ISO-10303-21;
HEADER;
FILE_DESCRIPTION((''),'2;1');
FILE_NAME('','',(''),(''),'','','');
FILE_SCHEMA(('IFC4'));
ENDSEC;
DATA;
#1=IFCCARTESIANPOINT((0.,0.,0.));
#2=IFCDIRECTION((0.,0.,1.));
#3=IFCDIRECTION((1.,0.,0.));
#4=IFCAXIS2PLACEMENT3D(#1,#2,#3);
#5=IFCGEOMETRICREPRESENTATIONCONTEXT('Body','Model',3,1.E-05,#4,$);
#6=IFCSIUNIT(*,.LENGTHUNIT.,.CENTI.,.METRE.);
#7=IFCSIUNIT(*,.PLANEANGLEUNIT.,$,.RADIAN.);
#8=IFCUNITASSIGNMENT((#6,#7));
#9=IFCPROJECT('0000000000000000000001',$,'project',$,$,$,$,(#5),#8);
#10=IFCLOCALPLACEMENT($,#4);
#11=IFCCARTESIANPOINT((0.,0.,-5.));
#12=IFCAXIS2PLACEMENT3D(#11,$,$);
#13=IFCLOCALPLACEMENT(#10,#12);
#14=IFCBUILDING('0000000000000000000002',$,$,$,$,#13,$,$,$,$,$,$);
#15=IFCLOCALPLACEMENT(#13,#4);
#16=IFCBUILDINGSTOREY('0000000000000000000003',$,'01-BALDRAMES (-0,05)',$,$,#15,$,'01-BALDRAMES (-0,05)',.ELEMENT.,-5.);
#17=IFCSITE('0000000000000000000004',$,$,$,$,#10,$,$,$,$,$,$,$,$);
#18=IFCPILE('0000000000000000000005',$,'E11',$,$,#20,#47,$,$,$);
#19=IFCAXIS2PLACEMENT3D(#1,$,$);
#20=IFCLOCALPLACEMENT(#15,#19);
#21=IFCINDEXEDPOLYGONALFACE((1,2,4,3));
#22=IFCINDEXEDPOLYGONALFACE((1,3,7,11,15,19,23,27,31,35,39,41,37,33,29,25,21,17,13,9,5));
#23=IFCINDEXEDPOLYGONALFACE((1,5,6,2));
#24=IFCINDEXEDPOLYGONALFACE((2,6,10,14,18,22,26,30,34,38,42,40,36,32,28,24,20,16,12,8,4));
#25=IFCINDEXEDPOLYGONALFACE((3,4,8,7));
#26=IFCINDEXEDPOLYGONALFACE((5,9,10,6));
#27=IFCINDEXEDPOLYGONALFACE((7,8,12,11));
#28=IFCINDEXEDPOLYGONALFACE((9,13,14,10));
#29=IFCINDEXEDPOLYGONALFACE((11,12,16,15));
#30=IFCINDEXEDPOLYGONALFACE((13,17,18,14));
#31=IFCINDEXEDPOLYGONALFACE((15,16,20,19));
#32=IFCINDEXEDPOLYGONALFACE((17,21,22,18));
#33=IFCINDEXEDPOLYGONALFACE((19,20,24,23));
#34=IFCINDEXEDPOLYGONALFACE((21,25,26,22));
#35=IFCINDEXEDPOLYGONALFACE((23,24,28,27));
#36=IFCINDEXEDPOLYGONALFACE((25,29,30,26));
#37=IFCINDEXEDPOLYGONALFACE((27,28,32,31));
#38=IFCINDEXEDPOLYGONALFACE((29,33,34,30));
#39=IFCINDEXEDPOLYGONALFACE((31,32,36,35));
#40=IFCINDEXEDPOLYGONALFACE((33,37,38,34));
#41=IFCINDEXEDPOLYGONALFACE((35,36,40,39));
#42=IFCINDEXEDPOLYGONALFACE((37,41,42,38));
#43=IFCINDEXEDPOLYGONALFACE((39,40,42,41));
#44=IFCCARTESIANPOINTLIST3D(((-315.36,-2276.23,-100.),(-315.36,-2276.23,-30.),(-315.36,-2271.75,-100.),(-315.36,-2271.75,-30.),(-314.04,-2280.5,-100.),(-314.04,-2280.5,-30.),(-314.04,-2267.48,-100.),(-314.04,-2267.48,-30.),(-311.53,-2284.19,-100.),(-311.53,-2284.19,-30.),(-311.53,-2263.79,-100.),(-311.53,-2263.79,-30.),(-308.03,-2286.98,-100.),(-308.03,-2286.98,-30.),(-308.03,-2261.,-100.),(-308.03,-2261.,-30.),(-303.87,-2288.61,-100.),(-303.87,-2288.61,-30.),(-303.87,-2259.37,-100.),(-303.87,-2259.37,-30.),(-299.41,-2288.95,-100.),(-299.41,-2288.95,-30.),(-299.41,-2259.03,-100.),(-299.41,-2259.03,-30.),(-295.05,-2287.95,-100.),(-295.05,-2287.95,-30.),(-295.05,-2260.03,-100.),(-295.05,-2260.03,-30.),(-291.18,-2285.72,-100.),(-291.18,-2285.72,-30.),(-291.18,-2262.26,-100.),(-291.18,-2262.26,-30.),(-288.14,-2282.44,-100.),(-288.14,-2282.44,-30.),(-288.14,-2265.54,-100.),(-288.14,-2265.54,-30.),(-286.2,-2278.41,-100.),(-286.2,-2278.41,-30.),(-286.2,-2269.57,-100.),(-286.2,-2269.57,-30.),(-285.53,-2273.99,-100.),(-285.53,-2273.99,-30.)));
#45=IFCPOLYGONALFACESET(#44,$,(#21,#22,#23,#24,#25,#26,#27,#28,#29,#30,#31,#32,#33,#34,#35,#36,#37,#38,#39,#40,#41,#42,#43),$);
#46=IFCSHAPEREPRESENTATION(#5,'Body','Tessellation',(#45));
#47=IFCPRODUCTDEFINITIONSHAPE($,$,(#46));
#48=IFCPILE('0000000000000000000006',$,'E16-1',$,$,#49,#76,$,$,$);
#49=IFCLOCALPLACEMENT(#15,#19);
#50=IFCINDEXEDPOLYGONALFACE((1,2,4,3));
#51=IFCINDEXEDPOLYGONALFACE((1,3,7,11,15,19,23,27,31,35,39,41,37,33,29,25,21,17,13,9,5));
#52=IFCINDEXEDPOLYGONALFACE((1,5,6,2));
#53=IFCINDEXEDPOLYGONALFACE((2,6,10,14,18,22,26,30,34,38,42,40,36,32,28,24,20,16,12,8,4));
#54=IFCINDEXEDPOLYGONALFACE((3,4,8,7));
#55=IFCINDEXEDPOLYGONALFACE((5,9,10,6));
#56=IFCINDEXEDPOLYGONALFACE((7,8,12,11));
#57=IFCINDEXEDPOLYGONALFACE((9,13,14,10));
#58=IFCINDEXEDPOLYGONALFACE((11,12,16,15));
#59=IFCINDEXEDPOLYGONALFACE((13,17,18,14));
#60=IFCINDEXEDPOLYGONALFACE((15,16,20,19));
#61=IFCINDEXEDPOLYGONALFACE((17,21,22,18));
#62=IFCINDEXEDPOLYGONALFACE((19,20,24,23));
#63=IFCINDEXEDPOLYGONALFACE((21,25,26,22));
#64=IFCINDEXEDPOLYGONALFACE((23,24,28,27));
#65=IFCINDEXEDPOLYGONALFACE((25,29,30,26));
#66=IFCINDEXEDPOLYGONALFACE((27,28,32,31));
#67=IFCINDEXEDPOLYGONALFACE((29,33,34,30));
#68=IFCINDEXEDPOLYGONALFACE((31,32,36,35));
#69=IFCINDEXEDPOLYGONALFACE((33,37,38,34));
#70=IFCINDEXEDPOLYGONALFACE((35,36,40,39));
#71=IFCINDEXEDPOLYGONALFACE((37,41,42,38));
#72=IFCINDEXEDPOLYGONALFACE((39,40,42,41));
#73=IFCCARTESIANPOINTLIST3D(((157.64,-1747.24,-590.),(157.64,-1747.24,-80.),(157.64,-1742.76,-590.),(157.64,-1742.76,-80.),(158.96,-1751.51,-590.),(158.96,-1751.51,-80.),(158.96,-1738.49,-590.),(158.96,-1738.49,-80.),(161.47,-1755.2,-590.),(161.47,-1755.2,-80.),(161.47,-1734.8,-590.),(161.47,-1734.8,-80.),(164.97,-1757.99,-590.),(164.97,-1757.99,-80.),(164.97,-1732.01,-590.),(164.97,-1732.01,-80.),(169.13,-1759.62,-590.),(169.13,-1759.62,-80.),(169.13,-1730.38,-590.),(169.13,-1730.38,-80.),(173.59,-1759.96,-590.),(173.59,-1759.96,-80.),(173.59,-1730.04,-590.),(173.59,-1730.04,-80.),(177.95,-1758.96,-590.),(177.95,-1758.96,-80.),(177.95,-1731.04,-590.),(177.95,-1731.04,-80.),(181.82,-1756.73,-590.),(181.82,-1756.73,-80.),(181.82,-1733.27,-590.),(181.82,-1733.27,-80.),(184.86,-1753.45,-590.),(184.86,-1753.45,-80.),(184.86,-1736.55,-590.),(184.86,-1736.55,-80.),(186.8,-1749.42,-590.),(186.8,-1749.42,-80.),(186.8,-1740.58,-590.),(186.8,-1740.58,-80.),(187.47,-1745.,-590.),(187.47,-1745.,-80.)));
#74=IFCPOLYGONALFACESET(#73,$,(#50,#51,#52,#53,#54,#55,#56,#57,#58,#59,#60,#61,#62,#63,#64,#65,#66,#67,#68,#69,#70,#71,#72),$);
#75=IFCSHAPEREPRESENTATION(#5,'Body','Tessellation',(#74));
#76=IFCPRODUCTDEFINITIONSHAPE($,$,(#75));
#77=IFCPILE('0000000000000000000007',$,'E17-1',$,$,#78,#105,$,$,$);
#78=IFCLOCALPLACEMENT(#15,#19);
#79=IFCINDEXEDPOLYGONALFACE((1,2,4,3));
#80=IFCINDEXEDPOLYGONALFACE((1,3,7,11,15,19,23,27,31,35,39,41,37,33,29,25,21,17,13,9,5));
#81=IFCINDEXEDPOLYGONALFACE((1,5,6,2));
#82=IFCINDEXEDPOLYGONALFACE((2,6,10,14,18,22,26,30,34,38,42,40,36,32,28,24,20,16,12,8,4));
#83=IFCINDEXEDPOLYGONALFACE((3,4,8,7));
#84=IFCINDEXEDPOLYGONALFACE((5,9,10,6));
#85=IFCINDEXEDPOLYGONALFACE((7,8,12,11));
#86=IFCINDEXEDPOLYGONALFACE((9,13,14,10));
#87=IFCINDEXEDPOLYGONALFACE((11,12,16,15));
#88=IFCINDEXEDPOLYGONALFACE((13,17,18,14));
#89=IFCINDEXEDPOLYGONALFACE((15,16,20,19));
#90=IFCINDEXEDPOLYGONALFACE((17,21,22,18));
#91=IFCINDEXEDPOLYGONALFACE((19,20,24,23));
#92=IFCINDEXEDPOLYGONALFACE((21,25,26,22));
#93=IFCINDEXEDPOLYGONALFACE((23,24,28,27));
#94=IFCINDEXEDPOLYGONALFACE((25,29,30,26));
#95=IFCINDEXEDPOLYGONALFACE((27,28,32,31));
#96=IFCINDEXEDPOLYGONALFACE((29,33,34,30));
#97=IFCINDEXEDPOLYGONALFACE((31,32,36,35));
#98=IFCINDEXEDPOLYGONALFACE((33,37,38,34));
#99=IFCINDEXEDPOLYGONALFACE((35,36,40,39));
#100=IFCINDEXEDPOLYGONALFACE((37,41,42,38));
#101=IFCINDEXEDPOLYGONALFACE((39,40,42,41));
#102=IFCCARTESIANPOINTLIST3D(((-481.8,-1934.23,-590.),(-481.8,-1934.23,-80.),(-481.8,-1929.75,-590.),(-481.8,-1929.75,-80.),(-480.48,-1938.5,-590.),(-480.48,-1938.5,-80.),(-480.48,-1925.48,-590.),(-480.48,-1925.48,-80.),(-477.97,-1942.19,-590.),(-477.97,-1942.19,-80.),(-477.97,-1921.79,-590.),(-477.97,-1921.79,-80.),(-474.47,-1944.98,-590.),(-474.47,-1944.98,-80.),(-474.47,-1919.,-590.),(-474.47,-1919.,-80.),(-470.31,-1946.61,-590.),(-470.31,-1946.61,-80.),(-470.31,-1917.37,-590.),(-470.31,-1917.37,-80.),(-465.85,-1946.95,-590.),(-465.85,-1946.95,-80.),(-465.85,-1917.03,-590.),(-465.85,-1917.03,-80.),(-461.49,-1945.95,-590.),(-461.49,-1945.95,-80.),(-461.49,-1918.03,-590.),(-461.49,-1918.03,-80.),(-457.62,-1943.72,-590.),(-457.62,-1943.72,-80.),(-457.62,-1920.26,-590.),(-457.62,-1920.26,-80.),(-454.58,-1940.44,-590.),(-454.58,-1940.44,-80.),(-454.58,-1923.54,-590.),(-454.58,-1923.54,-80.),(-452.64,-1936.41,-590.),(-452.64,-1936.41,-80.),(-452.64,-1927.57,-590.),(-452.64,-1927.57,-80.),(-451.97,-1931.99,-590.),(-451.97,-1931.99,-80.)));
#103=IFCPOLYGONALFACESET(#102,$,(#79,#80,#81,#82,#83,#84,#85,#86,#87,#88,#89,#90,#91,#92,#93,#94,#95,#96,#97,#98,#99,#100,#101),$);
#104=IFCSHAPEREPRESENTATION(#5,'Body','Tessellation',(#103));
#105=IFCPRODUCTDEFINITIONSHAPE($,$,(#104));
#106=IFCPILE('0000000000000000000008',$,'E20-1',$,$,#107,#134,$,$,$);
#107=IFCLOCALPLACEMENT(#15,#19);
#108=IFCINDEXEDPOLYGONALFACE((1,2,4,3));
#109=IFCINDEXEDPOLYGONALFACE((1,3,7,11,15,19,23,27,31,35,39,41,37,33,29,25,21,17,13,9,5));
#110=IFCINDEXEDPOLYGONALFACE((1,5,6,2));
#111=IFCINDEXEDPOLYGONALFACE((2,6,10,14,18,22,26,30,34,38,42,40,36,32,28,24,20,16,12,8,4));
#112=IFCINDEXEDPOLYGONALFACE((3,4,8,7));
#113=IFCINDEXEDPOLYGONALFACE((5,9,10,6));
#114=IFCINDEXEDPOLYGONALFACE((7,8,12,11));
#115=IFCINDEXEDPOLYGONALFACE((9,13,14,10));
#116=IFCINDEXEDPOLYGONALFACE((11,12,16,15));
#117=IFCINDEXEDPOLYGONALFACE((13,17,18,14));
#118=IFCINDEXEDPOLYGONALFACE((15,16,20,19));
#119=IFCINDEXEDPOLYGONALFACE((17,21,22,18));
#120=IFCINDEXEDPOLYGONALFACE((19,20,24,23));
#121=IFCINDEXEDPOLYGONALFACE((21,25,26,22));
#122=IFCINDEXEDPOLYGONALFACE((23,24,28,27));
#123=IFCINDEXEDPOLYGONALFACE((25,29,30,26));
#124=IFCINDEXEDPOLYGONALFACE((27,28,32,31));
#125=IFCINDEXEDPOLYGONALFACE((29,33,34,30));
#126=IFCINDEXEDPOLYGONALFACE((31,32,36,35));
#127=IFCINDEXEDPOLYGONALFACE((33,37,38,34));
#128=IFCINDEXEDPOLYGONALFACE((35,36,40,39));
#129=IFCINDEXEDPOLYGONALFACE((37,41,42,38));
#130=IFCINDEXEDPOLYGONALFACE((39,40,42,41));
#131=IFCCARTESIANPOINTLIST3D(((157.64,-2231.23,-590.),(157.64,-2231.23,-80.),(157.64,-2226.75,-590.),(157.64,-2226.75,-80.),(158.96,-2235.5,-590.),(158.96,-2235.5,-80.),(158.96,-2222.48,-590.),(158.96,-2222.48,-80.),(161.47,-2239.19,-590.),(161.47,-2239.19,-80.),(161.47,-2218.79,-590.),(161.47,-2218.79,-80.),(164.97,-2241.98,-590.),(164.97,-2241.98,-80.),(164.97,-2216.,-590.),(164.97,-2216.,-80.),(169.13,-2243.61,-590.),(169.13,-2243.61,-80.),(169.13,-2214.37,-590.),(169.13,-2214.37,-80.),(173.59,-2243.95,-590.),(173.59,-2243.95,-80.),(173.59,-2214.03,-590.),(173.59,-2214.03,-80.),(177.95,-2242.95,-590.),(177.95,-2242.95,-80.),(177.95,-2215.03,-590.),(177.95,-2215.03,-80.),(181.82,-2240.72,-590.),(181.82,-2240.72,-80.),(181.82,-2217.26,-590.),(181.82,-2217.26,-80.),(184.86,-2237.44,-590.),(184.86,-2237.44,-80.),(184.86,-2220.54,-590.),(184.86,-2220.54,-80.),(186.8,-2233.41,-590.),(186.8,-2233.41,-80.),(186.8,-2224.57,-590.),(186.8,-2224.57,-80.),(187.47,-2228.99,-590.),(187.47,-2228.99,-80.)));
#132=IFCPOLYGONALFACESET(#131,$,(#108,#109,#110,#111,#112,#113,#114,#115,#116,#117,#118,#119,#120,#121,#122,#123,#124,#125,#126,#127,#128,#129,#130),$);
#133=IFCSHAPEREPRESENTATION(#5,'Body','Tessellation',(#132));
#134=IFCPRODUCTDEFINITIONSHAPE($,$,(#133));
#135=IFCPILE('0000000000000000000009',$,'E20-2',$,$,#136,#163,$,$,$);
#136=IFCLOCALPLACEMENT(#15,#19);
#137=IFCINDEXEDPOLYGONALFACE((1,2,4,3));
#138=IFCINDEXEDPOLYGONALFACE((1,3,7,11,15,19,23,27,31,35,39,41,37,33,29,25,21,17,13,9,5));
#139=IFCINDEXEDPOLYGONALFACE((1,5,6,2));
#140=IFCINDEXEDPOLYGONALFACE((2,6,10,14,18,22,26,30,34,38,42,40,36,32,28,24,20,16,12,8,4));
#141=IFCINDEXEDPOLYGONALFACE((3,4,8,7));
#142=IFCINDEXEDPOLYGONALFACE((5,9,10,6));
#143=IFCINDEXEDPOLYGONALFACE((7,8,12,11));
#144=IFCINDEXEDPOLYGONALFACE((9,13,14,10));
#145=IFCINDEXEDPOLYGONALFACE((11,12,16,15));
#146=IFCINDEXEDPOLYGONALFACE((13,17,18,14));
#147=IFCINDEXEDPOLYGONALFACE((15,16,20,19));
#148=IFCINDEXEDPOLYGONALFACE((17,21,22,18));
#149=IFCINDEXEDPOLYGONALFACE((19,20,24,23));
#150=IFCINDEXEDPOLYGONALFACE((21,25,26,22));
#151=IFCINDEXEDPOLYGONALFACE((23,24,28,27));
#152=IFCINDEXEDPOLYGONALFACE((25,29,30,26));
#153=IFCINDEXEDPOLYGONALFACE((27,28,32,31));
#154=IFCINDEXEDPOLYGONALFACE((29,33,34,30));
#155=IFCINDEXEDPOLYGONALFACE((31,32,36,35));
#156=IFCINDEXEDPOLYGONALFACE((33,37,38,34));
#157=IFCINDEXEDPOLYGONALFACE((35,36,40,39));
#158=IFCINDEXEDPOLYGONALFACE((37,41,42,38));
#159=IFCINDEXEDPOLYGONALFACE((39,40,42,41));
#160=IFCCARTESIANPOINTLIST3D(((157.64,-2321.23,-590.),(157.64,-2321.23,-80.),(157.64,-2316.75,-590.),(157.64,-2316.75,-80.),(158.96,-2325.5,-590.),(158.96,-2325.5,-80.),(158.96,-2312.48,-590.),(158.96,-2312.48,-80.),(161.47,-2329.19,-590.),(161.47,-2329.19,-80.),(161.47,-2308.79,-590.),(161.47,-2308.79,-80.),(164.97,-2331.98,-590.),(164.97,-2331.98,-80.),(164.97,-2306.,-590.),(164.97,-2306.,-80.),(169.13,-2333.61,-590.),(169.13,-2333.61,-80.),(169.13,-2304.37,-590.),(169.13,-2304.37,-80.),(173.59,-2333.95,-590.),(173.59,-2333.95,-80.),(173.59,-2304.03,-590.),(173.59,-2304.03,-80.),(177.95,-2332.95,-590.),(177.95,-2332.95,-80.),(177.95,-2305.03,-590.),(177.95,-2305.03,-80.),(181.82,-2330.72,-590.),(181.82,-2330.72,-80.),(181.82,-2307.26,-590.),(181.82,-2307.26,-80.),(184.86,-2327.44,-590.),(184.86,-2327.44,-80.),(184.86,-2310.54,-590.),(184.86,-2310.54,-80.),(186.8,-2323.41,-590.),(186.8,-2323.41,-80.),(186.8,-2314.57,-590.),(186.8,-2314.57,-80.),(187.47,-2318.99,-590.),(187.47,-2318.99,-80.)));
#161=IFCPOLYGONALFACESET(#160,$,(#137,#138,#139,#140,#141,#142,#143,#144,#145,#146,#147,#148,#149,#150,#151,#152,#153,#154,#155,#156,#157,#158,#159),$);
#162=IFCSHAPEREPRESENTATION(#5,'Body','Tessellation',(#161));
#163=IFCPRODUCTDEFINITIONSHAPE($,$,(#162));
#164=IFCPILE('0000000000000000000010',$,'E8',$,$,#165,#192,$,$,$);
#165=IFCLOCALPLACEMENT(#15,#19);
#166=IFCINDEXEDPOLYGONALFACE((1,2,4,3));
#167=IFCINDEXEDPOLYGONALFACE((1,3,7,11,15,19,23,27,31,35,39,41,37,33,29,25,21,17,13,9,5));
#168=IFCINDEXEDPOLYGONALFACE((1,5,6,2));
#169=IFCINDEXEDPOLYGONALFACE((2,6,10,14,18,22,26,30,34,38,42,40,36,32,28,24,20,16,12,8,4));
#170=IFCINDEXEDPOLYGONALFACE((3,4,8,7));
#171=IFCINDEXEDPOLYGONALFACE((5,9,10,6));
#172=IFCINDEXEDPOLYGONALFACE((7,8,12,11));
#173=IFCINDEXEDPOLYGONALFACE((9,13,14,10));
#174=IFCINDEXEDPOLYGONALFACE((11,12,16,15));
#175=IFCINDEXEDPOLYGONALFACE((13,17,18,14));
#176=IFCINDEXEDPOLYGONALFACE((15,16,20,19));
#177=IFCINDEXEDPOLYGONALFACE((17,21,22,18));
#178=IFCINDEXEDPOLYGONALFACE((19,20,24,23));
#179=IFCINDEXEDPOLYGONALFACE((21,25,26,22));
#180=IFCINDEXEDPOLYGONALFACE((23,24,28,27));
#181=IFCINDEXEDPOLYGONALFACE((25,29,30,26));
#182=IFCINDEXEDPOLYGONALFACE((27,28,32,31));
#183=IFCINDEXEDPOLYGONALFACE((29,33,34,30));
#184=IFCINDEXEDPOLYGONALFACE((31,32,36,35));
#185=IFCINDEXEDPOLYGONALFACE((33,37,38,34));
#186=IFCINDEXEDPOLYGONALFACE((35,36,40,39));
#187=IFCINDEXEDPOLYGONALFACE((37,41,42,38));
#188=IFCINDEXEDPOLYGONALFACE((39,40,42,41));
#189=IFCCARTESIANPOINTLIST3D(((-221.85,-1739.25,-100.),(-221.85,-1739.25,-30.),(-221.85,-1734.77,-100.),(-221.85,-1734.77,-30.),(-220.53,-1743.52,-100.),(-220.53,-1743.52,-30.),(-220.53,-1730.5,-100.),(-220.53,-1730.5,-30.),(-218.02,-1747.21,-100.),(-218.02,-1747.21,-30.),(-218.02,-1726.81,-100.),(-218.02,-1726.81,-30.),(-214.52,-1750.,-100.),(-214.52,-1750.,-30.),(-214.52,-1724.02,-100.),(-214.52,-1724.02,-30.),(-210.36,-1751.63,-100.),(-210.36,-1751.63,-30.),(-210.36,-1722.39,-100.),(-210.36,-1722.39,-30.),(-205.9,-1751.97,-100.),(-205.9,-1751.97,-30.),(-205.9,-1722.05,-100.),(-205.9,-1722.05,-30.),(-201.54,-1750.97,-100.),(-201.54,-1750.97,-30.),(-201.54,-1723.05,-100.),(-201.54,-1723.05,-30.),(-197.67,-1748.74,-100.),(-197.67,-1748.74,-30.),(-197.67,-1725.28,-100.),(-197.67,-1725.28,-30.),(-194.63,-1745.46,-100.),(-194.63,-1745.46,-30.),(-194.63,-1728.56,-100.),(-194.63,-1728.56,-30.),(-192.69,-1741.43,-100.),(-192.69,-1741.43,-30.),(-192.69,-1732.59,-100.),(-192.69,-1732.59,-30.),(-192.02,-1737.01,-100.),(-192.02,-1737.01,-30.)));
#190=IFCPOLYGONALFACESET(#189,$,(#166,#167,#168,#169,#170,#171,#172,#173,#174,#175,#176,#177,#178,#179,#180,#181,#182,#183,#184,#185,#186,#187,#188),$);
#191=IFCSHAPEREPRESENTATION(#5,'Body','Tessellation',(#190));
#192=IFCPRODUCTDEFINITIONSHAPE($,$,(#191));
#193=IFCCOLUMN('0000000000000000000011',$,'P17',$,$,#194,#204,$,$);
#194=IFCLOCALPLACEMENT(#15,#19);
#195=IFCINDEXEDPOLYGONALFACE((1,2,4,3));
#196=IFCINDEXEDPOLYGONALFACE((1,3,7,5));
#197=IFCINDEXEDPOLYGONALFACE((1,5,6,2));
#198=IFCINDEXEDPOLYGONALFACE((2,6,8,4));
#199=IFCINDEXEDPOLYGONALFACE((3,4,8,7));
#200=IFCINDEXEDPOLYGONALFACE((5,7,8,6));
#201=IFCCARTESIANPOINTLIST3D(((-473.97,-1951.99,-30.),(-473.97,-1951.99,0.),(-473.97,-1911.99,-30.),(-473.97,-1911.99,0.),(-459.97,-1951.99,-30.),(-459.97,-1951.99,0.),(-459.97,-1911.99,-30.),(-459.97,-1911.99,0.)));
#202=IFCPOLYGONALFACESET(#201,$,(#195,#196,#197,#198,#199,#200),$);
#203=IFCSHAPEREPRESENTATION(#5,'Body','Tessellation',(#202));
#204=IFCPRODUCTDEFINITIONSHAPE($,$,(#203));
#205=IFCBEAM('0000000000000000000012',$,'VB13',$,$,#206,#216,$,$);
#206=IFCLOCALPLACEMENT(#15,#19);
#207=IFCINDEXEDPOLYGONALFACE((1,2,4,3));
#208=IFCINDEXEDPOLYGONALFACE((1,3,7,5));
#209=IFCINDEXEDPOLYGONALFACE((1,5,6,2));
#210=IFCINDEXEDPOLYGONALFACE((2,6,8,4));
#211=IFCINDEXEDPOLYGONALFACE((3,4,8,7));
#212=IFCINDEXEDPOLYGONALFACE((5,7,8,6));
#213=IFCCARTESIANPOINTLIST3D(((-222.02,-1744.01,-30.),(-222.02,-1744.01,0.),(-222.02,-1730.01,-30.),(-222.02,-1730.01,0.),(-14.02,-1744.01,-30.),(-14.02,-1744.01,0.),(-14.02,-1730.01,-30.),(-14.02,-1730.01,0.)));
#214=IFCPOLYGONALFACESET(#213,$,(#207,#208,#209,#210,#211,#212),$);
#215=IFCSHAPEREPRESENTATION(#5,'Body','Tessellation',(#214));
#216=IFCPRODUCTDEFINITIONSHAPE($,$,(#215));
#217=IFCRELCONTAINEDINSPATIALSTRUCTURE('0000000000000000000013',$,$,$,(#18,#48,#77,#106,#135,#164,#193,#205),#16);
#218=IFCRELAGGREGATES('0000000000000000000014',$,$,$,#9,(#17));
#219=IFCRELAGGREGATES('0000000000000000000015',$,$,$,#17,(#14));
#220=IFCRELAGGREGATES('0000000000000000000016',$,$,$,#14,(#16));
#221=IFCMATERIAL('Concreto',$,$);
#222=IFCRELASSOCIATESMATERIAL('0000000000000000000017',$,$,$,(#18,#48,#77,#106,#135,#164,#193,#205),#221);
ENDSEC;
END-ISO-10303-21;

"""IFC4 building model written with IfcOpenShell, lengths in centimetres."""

from ifc_helpers import new_model, si_unit, frame, origin_with_axes, origin_2d_with_axis, place, context, project, spatial, rectangle, circle, extrude, material, element, save


model = new_model("IFC4")

# Units and contexts
model_context = context("Model", 3, precision=1e-05, world=origin_with_axes(), identifier="Body")
ifc_project = project(units=[si_unit("LENGTHUNIT", "METRE", prefix="CENTI"), si_unit("PLANEANGLEUNIT", "RADIAN")], contexts=[model_context])

# Site, building, storey
site_placement = place(None, origin_with_axes())
site = spatial("IfcSite", under=ifc_project, at=site_placement)
building_placement = place(site_placement, frame((0.0, 0.0, -5.0)))
building = spatial("IfcBuilding", under=site, at=building_placement)
storey_placement = place(building_placement, origin_with_axes())
storey = spatial("IfcBuildingStorey", under=building, at=storey_placement, Name="01-BALDRAMES (-0,05)", LongName="01-BALDRAMES (-0,05)", CompositionType="ELEMENT", Elevation=-5.0)

# Piles
ifc_material = material(Name="Concreto")
pile_1_placement = place(storey_placement, frame((-300.53, -2273.99, -30.0), z_axis=(0.0, 0.0, 1.0), x_axis=(1.0, 0.0, 0.0)))
element("IfcPile", 1, at=pile_1_placement, inside=storey, material=ifc_material, Name="E11", context=model_context, shape_type="SolidModel", body=[
    extrude(circle(Radius=15.0, at=origin_2d_with_axis()), frame((0.0, 0.0, -70.0), z_axis=(0.0, 0.0, 1.0), x_axis=(1.0, 0.0, 0.0)), (0.0, 0.0, 1.0), 70.0),
])
for number, where, z_axis, x_axis, name in (
    (2, (172.47, -1745.0, -80.0), (0.0, 0.0, 1.0), (1.0, 0.0, 0.0), "E16-1"),
    (3, (-466.97, -1931.99, -80.0), (0.0, 0.0, 1.0), (1.0, 0.0, 0.0), "E17-1"),
    (4, (172.47, -2228.99, -80.0), (0.0, 0.0, 1.0), (1.0, 0.0, 0.0), "E20-1"),
    (5, (172.47, -2318.99, -80.0), (0.0, 0.0, 1.0), (1.0, 0.0, 0.0), "E20-2"),
):
    element("IfcPile", number, at=place(storey_placement, frame(where, z_axis=z_axis, x_axis=x_axis)), inside=storey, material=ifc_material, Name=name, context=model_context, shape_type="SweptSolid", body=[
        extrude(circle(Radius=15.0, at=origin_2d_with_axis()), frame((0.0, 0.0, -510.0), z_axis=(0.0, 0.0, 1.0), x_axis=(1.0, 0.0, 0.0)), (0.0, 0.0, 1.0), 510.0),
    ])
pile_2_placement = place(storey_placement, frame((-207.02, -1737.01, -30.0), z_axis=(0.0, 0.0, 1.0), x_axis=(1.0, 0.0, 0.0)))
element("IfcPile", 6, at=pile_2_placement, inside=storey, material=ifc_material, Name="E8", context=model_context, shape_type="SolidModel", body=[
    extrude(circle(Radius=15.0, at=origin_2d_with_axis()), frame((0.0, 0.0, -70.0), z_axis=(0.0, 0.0, 1.0), x_axis=(1.0, 0.0, 0.0)), (0.0, 0.0, 1.0), 70.0),
])

# Column
column_placement = place(storey_placement, frame((-466.97, -1931.99, 0.0), z_axis=(0.0, 0.0, 1.0), x_axis=(1.0, 0.0, 0.0)))
element("IfcColumn", 7, at=column_placement, inside=storey, material=ifc_material, Name="P17", context=model_context, shape_type="SolidModel", body=[
    extrude(rectangle(XDim=14.0, YDim=40.0, at=origin_2d_with_axis()), origin_with_axes(), (0.0, 0.0, -1.0), 30.0),
])

# Beam
beam_1_placement = place(storey_placement, frame((-118.02, -1737.01, 0.0), z_axis=(0.0, 0.0, 1.0), x_axis=(1.0, 0.0, 0.0)))
element("IfcBeam", 8, at=beam_1_placement, inside=storey, material=ifc_material, Name="VB13", context=model_context, shape_type="SolidModel", body=[
    extrude(rectangle(XDim=14.0, YDim=30.0, at=origin_2d_with_axis()), frame((-104.0, 0.0, -15.0), z_axis=(1.0, 0.0, 0.0), x_axis=(0.0, -1.0, 0.0)), (0.0, 0.0, 1.0), 208.0),
])

save(model, "model.ifc")
